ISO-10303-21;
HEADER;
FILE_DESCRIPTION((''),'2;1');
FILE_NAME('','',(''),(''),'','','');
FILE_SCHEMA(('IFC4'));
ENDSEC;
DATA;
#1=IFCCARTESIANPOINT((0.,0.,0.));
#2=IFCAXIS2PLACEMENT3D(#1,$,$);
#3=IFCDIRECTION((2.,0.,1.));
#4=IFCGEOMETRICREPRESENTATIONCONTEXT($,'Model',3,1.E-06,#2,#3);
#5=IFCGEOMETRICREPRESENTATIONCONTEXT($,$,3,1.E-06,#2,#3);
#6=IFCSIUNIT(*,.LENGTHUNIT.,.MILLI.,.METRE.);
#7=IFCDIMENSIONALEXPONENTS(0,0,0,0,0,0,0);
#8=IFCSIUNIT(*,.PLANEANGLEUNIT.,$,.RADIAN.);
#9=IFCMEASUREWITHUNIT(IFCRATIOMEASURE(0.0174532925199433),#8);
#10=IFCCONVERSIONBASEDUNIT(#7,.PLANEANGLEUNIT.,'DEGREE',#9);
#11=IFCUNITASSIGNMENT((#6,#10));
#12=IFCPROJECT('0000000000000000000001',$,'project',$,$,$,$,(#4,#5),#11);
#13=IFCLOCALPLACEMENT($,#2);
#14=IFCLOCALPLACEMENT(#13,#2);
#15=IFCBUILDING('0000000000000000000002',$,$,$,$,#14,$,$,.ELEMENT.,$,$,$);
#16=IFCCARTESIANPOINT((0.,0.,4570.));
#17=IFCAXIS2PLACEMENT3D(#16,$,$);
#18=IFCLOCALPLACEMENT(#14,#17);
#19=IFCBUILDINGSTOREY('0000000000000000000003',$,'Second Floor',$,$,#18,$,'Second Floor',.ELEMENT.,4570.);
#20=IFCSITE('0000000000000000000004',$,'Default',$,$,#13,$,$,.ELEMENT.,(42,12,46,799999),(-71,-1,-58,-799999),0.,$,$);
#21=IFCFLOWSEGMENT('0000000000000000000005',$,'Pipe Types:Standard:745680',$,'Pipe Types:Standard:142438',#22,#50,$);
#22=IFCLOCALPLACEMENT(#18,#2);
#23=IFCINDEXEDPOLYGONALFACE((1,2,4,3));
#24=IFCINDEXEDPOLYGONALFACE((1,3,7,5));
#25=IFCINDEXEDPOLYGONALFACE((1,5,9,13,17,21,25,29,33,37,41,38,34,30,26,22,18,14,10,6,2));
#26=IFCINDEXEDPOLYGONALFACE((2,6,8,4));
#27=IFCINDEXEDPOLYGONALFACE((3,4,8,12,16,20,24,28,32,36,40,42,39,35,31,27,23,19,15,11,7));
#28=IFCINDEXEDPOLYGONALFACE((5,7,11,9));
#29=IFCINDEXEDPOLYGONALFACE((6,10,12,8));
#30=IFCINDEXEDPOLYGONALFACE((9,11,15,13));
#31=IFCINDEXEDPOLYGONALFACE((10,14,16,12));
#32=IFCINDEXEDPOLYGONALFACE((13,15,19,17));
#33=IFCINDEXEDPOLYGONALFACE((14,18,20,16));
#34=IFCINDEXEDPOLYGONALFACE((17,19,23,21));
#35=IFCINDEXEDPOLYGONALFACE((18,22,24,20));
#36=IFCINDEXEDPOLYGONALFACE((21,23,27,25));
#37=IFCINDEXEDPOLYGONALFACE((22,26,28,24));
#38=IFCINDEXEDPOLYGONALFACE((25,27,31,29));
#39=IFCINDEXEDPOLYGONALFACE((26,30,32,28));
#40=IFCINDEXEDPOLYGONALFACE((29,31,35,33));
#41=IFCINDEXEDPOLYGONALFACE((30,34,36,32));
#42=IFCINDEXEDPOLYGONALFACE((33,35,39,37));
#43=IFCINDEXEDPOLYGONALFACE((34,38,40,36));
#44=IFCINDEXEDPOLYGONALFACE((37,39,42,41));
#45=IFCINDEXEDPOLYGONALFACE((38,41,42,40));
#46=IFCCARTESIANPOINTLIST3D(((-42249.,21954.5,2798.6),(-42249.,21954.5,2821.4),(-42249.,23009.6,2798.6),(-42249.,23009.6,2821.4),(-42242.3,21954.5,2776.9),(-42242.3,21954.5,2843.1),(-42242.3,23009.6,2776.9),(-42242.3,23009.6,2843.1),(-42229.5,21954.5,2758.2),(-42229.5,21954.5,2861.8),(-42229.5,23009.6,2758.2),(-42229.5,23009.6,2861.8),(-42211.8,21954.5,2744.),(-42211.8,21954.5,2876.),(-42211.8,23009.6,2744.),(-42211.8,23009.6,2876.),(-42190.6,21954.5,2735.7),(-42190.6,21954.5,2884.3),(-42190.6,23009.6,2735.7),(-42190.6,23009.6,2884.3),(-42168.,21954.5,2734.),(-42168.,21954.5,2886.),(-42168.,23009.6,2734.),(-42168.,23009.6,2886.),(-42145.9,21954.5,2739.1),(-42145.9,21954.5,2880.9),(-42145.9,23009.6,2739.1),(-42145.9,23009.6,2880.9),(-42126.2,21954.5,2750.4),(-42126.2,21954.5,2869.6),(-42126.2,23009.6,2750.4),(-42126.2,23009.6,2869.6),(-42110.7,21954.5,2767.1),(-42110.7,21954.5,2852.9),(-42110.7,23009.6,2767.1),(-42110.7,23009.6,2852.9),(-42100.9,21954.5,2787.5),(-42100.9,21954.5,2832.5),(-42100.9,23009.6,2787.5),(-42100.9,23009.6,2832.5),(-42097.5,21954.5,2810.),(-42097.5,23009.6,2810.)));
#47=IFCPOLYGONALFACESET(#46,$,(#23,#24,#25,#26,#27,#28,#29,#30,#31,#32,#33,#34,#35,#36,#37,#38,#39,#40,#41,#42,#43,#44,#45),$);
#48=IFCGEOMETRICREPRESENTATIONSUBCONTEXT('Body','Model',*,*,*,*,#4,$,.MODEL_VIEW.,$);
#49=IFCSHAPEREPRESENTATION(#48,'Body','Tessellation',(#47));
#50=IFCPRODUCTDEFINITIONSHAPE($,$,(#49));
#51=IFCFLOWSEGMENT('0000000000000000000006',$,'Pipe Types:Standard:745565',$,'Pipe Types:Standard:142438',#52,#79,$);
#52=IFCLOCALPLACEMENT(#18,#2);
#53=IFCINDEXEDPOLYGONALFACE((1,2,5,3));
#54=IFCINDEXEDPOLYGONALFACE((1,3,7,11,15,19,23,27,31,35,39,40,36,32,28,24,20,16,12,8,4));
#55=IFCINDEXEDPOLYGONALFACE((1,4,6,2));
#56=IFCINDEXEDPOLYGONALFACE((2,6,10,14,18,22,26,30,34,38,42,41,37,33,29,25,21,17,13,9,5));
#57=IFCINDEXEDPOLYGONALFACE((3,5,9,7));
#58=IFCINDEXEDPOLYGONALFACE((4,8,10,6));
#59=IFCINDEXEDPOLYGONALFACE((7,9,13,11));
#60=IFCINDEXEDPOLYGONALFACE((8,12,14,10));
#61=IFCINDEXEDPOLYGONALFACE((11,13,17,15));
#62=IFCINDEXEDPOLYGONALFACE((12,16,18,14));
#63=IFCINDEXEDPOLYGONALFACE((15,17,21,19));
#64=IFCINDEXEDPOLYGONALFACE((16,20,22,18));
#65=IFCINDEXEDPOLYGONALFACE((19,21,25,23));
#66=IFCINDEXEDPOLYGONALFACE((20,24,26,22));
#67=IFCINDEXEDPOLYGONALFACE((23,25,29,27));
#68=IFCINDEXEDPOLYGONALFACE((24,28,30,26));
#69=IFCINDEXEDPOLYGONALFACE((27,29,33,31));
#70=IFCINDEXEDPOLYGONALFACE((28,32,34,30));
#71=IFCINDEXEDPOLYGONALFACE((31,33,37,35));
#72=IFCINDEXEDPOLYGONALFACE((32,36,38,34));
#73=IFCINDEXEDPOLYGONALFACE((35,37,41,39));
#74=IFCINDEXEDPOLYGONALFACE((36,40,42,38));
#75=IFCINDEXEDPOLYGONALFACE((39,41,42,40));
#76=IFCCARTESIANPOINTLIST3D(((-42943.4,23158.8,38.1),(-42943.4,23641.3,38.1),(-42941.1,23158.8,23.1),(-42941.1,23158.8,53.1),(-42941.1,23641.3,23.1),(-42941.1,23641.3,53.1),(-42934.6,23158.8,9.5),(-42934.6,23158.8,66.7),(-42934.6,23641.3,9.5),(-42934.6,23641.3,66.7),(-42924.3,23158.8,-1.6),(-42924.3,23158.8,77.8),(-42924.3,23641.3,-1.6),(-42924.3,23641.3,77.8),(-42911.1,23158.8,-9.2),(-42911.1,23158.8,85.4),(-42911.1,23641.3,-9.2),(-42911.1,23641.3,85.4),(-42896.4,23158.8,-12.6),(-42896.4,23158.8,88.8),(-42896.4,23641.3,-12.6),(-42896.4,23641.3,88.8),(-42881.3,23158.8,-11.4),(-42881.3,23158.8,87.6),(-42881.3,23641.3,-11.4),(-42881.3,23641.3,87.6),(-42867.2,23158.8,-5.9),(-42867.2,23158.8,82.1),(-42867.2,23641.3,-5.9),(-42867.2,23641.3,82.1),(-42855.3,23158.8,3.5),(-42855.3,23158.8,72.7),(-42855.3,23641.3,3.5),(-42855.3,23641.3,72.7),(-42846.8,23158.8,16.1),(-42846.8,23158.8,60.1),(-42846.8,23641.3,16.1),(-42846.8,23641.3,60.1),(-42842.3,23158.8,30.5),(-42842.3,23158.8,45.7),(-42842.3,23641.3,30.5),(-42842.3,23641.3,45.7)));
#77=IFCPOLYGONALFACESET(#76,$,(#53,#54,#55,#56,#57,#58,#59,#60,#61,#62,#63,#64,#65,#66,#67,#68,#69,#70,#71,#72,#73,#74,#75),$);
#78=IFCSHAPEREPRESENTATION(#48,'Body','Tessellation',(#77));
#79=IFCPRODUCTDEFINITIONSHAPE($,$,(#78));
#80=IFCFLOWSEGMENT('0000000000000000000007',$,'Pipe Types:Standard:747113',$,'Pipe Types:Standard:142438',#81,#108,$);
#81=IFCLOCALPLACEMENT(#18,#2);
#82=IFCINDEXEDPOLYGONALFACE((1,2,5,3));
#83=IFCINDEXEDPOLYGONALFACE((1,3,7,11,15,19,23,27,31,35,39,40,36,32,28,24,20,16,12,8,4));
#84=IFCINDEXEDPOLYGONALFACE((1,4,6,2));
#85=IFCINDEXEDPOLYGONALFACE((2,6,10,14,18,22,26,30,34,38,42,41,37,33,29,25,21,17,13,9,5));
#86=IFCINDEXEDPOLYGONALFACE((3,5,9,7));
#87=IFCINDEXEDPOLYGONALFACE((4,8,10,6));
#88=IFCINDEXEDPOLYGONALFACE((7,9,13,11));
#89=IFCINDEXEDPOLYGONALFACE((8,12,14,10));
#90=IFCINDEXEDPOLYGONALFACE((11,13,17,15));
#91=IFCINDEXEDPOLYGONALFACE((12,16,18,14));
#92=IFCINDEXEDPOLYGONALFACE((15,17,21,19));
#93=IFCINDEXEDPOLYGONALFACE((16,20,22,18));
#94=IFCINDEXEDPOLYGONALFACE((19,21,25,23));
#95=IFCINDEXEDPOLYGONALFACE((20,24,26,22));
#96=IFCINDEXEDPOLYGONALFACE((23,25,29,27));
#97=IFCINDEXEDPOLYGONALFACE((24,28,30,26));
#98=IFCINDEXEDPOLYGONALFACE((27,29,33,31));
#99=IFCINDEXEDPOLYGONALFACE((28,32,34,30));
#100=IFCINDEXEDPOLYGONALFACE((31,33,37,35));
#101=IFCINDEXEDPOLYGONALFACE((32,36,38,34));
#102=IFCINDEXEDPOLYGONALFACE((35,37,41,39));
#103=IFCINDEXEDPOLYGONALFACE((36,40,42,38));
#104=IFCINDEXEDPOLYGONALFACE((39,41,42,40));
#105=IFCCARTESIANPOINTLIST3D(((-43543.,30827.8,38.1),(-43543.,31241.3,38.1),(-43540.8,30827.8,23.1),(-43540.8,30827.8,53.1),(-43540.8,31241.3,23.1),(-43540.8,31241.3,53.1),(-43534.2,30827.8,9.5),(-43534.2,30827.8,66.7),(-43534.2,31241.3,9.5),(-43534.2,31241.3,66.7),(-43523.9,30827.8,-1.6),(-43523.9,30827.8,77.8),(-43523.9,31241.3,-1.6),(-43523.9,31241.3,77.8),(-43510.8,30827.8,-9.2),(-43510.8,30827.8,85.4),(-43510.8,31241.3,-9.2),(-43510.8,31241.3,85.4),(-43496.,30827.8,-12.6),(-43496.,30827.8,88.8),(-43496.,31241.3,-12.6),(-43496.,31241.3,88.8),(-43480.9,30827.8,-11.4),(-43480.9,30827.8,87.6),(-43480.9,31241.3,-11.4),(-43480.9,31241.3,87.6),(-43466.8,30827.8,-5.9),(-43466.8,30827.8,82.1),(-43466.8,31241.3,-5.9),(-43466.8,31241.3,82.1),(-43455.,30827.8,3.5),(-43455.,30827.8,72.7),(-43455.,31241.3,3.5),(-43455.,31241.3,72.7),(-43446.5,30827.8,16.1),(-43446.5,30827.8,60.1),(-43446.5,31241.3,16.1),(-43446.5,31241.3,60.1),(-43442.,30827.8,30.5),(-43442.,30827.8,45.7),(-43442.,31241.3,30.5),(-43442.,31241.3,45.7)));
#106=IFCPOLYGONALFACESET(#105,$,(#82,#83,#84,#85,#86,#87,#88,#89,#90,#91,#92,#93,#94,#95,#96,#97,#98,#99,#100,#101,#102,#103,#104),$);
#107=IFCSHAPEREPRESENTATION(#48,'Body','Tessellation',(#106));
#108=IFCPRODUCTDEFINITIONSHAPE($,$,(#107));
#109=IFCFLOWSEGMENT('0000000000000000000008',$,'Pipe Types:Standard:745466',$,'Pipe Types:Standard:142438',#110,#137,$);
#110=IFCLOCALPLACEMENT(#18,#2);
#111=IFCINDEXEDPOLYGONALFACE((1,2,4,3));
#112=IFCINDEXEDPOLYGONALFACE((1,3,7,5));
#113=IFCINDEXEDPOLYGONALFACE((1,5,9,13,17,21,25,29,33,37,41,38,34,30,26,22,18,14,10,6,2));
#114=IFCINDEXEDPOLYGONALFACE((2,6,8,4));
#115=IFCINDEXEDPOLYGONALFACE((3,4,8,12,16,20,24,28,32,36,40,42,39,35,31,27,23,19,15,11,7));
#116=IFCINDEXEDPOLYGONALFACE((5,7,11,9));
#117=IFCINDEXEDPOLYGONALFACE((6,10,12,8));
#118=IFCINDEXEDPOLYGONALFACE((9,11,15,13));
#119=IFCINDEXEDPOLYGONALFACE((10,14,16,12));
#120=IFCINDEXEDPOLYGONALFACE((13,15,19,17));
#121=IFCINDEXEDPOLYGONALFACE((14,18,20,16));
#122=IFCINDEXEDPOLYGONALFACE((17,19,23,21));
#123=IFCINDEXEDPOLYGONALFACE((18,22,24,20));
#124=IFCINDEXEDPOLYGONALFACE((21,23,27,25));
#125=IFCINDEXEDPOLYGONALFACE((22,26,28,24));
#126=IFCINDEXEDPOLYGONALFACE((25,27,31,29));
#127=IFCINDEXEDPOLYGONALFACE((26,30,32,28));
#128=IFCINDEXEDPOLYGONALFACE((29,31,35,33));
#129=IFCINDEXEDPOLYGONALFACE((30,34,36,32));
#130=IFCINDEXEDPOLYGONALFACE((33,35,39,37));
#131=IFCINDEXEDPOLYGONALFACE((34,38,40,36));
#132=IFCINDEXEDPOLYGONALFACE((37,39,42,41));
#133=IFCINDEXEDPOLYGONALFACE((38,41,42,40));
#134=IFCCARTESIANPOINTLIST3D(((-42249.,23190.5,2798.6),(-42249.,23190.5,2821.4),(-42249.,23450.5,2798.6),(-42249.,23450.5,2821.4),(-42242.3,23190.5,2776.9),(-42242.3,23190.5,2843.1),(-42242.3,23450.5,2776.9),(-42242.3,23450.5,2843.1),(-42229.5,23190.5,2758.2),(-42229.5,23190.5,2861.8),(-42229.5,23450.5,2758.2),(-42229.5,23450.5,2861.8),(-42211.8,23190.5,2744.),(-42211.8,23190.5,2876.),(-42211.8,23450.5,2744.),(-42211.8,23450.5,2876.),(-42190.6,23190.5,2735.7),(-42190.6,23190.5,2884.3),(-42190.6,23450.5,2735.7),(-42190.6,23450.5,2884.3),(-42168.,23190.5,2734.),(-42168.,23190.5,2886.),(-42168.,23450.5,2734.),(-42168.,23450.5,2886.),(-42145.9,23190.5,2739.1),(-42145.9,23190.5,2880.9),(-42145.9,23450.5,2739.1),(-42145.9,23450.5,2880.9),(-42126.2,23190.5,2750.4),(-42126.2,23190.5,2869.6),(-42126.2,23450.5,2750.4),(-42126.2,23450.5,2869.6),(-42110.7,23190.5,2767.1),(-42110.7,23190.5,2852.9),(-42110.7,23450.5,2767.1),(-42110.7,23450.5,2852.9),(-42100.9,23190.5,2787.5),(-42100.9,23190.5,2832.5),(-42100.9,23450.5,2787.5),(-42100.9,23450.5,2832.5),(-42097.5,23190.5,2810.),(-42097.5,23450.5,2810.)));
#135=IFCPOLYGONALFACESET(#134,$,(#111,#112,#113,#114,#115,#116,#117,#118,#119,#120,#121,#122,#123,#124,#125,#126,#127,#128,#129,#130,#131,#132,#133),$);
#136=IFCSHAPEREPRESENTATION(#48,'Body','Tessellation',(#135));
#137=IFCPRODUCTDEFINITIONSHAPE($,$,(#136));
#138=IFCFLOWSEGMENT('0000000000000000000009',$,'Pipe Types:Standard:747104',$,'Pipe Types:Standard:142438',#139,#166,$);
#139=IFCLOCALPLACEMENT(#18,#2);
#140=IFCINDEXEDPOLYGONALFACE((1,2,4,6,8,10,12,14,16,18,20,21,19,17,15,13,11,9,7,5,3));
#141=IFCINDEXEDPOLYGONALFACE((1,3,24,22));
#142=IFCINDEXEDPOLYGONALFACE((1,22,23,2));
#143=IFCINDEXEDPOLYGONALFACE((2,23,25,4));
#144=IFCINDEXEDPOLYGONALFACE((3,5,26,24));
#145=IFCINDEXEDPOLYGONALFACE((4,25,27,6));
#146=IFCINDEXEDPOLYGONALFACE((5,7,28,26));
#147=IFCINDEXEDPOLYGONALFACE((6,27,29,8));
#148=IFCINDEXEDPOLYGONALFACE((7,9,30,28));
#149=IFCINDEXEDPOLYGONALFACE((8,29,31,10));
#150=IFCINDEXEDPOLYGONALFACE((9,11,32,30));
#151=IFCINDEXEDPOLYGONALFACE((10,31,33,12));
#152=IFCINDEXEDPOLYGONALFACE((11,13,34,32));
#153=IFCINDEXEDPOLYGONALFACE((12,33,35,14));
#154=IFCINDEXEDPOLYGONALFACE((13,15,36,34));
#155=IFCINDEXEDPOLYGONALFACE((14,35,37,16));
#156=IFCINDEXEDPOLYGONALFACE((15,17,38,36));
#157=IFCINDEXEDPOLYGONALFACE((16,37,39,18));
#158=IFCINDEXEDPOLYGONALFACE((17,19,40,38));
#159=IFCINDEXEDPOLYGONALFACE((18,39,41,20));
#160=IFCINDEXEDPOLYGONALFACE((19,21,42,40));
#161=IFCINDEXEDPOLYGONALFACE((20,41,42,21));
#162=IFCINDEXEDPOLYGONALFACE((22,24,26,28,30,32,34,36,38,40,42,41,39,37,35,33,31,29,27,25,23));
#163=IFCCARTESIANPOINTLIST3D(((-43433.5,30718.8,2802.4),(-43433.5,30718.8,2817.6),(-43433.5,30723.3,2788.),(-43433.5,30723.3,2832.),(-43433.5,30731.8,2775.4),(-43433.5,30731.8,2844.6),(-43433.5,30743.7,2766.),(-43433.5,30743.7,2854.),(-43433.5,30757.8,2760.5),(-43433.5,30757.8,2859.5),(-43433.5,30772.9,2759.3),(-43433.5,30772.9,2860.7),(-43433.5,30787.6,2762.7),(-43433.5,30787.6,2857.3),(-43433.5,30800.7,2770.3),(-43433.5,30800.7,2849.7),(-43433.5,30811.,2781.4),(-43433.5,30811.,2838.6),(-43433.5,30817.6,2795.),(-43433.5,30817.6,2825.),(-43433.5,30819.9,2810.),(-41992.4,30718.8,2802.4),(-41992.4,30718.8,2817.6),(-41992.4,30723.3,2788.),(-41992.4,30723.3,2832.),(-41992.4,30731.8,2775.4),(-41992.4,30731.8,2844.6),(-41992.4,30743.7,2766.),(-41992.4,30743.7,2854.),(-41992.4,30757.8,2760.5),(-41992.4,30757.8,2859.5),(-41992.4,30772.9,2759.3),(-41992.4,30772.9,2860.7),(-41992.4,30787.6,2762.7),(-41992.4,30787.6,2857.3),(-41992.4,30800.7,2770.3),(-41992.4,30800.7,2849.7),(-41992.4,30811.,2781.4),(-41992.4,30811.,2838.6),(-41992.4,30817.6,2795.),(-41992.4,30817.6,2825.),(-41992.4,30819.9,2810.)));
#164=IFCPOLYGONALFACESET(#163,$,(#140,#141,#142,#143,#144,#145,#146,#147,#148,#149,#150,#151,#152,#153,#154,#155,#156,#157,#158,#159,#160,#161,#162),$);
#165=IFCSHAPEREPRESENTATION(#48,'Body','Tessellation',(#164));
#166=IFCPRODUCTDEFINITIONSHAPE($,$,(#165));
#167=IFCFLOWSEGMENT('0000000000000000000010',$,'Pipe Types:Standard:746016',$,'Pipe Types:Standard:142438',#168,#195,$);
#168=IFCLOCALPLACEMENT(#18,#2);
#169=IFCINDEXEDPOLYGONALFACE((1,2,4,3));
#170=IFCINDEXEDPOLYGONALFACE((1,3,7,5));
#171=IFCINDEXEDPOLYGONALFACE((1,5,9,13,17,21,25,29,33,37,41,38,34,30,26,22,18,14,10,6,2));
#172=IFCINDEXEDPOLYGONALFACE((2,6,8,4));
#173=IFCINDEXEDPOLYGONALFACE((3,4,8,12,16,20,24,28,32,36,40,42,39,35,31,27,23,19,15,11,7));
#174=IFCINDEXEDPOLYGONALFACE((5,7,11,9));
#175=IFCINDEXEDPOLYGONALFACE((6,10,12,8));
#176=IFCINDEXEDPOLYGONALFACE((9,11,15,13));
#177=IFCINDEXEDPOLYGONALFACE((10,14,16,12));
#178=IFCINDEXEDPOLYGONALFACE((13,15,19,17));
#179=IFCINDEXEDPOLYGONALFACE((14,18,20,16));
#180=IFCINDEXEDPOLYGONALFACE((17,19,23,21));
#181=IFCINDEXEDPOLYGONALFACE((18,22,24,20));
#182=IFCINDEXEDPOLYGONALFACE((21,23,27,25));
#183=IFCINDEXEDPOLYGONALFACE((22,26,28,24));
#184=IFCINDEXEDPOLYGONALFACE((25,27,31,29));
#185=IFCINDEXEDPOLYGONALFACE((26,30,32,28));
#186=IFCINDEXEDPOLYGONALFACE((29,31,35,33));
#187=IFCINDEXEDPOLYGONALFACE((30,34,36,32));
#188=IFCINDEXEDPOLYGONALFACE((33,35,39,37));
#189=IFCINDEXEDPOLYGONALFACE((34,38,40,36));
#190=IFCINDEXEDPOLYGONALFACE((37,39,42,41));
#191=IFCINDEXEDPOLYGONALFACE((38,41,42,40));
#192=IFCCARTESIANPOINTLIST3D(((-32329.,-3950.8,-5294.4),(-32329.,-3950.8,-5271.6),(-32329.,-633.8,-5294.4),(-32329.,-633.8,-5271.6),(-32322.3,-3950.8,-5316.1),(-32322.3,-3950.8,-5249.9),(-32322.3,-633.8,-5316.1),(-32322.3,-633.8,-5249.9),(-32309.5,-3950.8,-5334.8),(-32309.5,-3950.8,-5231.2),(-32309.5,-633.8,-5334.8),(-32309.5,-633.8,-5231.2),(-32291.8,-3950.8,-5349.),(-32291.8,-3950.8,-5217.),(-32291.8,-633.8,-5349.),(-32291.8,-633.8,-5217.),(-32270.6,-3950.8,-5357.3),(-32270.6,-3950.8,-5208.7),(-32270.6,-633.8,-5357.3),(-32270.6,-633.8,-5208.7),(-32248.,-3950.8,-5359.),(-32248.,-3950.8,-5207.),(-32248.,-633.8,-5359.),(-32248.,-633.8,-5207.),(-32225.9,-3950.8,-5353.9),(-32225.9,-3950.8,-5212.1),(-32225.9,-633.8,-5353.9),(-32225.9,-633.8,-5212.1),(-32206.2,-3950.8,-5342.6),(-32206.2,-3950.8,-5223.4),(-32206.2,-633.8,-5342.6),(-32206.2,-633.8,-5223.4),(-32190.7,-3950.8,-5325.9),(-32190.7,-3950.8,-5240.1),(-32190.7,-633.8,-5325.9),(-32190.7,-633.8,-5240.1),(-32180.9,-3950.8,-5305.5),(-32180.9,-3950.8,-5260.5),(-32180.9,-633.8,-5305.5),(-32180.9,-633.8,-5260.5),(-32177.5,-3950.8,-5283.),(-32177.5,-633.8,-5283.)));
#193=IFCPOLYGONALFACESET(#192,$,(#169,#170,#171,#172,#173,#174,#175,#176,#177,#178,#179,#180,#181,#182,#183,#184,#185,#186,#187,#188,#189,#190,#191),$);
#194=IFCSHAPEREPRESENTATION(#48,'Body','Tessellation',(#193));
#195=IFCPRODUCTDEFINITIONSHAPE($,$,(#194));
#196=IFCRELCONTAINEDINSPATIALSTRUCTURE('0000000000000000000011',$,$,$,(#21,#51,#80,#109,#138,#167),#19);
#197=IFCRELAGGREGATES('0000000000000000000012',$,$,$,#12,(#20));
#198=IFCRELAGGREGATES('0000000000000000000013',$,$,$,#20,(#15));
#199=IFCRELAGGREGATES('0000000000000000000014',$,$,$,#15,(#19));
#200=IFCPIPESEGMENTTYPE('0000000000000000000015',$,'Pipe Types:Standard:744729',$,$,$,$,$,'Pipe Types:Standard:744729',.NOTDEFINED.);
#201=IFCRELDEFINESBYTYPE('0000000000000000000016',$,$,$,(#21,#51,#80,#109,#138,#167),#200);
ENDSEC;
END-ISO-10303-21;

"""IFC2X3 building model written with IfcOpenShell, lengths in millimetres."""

from ifc_helpers import new_model, entity, si_unit, converted_unit, direction, frame, frame_2d, origin, origin_2d_with_axis, place, context, subcontext, project, spatial, circle, extrude, type_object, element, save


model = new_model("IFC2X3")

# Units and contexts
model_context = context("Model", 3, precision=1e-06, world=origin(), true_north=direction((2.0, 0.0, 1.0)))
context_of_model = context(None, 3, precision=1e-06, world=origin(), true_north=direction((2.0, 0.0, 1.0)))
body_context = subcontext(model_context, "Body", "Model", "MODEL_VIEW")
ifc_project = project(units=[si_unit("LENGTHUNIT", "METRE", prefix="MILLI"), converted_unit("PLANEANGLEUNIT", "DEGREE", entity("IfcRatioMeasure", 0.0174532925199433), si_unit("PLANEANGLEUNIT", "RADIAN"), dimensions=[0, 0, 0, 0, 0, 0, 0])], contexts=[model_context, context_of_model])

# Site, building, storey
site_placement = place(None, origin())
site = spatial("IfcSite", under=ifc_project, at=site_placement, Name="Default", CompositionType="ELEMENT", RefLatitude=(42, 12, 46, 799999), RefLongitude=(-71, -1, -58, -799999), RefElevation=0.0)
building_placement = place(site_placement, origin())
building = spatial("IfcBuilding", under=site, at=building_placement, CompositionType="ELEMENT")
storey_placement = place(building_placement, frame((0.0, 0.0, 4570.0)))
storey = spatial("IfcBuildingStorey", under=building, at=storey_placement, Name="Second Floor", LongName="Second Floor", CompositionType="ELEMENT", Elevation=4570.0)

# Flow segments
pipe_segment_type = type_object("IfcPipeSegmentType", Name="Pipe Types:Standard:744729", ElementType="Pipe Types:Standard:744729", PredefinedType="NOTDEFINED")
flow_segment_1_placement = place(storey_placement, origin())
element("IfcFlowSegment", 1, at=flow_segment_1_placement, inside=storey, type_object=pipe_segment_type, Name="Pipe Types:Standard:745680", ObjectType="Pipe Types:Standard:142438", context=body_context, shape_type="SweptSolid", body=[
    extrude(circle(Radius=76.2, at=origin_2d_with_axis()), frame((-42173.7, 21954.5, 2810.0), z_axis=(0.0, 1.0, 0.0), x_axis=(1.0, 0.0, 0.0)), (0.0, 0.0, 1.0), 1055.1),
])
flow_segment_2_placement = place(storey_placement, origin())
element("IfcFlowSegment", 2, at=flow_segment_2_placement, inside=storey, type_object=pipe_segment_type, Name="Pipe Types:Standard:745565", ObjectType="Pipe Types:Standard:142438", context=body_context, shape_type="SweptSolid", body=[
    extrude(circle(Radius=50.8, at=origin_2d_with_axis()), frame((-42892.6, 23158.8, 38.1), z_axis=(0.0, 1.0, 0.0), x_axis=(-1.0, 0.0, 0.0)), (0.0, 0.0, 1.0), 482.5),
])
flow_segment_3_placement = place(storey_placement, origin())
element("IfcFlowSegment", 3, at=flow_segment_3_placement, inside=storey, type_object=pipe_segment_type, Name="Pipe Types:Standard:747113", ObjectType="Pipe Types:Standard:142438", context=body_context, shape_type="SweptSolid", body=[
    extrude(circle(Radius=50.8, at=origin_2d_with_axis()), frame((-43492.2, 30827.8, 38.1), z_axis=(0.0, 1.0, 0.0), x_axis=(-1.0, 0.0, 0.0)), (0.0, 0.0, 1.0), 413.5),
])
flow_segment_4_placement = place(storey_placement, origin())
element("IfcFlowSegment", 4, at=flow_segment_4_placement, inside=storey, type_object=pipe_segment_type, Name="Pipe Types:Standard:745466", ObjectType="Pipe Types:Standard:142438", context=body_context, shape_type="SweptSolid", body=[
    extrude(circle(Radius=76.2, at=origin_2d_with_axis()), frame((-42173.7, 23190.5, 2810.0), z_axis=(0.0, 1.0, 0.0), x_axis=(1.0, 0.0, 0.0)), (0.0, 0.0, 1.0), 260.0),
])
flow_segment_5_placement = place(storey_placement, origin())
element("IfcFlowSegment", 5, at=flow_segment_5_placement, inside=storey, type_object=pipe_segment_type, Name="Pipe Types:Standard:747104", ObjectType="Pipe Types:Standard:142438", context=body_context, shape_type="SweptSolid", body=[
    extrude(circle(Radius=50.8, at=frame_2d((0.0, 0.0), x_axis=(1.0, 0.0))), frame((-43433.5, 30769.1, 2810.0), z_axis=(1.0, 0.0, 0.0), x_axis=(0.0, 1.0, 0.0)), (0.0, 0.0, 1.0), 1441.1),
])
flow_segment_6_placement = place(storey_placement, origin())
element("IfcFlowSegment", 6, at=flow_segment_6_placement, inside=storey, type_object=pipe_segment_type, Name="Pipe Types:Standard:746016", ObjectType="Pipe Types:Standard:142438", context=body_context, shape_type="SweptSolid", body=[
    extrude(circle(Radius=76.2, at=origin_2d_with_axis()), frame((-32253.7, -3950.8, -5283.0), z_axis=(0.0, 1.0, 0.0), x_axis=(1.0, 0.0, 0.0)), (0.0, 0.0, 1.0), 3317.0),
])

save(model, "model.ifc")
